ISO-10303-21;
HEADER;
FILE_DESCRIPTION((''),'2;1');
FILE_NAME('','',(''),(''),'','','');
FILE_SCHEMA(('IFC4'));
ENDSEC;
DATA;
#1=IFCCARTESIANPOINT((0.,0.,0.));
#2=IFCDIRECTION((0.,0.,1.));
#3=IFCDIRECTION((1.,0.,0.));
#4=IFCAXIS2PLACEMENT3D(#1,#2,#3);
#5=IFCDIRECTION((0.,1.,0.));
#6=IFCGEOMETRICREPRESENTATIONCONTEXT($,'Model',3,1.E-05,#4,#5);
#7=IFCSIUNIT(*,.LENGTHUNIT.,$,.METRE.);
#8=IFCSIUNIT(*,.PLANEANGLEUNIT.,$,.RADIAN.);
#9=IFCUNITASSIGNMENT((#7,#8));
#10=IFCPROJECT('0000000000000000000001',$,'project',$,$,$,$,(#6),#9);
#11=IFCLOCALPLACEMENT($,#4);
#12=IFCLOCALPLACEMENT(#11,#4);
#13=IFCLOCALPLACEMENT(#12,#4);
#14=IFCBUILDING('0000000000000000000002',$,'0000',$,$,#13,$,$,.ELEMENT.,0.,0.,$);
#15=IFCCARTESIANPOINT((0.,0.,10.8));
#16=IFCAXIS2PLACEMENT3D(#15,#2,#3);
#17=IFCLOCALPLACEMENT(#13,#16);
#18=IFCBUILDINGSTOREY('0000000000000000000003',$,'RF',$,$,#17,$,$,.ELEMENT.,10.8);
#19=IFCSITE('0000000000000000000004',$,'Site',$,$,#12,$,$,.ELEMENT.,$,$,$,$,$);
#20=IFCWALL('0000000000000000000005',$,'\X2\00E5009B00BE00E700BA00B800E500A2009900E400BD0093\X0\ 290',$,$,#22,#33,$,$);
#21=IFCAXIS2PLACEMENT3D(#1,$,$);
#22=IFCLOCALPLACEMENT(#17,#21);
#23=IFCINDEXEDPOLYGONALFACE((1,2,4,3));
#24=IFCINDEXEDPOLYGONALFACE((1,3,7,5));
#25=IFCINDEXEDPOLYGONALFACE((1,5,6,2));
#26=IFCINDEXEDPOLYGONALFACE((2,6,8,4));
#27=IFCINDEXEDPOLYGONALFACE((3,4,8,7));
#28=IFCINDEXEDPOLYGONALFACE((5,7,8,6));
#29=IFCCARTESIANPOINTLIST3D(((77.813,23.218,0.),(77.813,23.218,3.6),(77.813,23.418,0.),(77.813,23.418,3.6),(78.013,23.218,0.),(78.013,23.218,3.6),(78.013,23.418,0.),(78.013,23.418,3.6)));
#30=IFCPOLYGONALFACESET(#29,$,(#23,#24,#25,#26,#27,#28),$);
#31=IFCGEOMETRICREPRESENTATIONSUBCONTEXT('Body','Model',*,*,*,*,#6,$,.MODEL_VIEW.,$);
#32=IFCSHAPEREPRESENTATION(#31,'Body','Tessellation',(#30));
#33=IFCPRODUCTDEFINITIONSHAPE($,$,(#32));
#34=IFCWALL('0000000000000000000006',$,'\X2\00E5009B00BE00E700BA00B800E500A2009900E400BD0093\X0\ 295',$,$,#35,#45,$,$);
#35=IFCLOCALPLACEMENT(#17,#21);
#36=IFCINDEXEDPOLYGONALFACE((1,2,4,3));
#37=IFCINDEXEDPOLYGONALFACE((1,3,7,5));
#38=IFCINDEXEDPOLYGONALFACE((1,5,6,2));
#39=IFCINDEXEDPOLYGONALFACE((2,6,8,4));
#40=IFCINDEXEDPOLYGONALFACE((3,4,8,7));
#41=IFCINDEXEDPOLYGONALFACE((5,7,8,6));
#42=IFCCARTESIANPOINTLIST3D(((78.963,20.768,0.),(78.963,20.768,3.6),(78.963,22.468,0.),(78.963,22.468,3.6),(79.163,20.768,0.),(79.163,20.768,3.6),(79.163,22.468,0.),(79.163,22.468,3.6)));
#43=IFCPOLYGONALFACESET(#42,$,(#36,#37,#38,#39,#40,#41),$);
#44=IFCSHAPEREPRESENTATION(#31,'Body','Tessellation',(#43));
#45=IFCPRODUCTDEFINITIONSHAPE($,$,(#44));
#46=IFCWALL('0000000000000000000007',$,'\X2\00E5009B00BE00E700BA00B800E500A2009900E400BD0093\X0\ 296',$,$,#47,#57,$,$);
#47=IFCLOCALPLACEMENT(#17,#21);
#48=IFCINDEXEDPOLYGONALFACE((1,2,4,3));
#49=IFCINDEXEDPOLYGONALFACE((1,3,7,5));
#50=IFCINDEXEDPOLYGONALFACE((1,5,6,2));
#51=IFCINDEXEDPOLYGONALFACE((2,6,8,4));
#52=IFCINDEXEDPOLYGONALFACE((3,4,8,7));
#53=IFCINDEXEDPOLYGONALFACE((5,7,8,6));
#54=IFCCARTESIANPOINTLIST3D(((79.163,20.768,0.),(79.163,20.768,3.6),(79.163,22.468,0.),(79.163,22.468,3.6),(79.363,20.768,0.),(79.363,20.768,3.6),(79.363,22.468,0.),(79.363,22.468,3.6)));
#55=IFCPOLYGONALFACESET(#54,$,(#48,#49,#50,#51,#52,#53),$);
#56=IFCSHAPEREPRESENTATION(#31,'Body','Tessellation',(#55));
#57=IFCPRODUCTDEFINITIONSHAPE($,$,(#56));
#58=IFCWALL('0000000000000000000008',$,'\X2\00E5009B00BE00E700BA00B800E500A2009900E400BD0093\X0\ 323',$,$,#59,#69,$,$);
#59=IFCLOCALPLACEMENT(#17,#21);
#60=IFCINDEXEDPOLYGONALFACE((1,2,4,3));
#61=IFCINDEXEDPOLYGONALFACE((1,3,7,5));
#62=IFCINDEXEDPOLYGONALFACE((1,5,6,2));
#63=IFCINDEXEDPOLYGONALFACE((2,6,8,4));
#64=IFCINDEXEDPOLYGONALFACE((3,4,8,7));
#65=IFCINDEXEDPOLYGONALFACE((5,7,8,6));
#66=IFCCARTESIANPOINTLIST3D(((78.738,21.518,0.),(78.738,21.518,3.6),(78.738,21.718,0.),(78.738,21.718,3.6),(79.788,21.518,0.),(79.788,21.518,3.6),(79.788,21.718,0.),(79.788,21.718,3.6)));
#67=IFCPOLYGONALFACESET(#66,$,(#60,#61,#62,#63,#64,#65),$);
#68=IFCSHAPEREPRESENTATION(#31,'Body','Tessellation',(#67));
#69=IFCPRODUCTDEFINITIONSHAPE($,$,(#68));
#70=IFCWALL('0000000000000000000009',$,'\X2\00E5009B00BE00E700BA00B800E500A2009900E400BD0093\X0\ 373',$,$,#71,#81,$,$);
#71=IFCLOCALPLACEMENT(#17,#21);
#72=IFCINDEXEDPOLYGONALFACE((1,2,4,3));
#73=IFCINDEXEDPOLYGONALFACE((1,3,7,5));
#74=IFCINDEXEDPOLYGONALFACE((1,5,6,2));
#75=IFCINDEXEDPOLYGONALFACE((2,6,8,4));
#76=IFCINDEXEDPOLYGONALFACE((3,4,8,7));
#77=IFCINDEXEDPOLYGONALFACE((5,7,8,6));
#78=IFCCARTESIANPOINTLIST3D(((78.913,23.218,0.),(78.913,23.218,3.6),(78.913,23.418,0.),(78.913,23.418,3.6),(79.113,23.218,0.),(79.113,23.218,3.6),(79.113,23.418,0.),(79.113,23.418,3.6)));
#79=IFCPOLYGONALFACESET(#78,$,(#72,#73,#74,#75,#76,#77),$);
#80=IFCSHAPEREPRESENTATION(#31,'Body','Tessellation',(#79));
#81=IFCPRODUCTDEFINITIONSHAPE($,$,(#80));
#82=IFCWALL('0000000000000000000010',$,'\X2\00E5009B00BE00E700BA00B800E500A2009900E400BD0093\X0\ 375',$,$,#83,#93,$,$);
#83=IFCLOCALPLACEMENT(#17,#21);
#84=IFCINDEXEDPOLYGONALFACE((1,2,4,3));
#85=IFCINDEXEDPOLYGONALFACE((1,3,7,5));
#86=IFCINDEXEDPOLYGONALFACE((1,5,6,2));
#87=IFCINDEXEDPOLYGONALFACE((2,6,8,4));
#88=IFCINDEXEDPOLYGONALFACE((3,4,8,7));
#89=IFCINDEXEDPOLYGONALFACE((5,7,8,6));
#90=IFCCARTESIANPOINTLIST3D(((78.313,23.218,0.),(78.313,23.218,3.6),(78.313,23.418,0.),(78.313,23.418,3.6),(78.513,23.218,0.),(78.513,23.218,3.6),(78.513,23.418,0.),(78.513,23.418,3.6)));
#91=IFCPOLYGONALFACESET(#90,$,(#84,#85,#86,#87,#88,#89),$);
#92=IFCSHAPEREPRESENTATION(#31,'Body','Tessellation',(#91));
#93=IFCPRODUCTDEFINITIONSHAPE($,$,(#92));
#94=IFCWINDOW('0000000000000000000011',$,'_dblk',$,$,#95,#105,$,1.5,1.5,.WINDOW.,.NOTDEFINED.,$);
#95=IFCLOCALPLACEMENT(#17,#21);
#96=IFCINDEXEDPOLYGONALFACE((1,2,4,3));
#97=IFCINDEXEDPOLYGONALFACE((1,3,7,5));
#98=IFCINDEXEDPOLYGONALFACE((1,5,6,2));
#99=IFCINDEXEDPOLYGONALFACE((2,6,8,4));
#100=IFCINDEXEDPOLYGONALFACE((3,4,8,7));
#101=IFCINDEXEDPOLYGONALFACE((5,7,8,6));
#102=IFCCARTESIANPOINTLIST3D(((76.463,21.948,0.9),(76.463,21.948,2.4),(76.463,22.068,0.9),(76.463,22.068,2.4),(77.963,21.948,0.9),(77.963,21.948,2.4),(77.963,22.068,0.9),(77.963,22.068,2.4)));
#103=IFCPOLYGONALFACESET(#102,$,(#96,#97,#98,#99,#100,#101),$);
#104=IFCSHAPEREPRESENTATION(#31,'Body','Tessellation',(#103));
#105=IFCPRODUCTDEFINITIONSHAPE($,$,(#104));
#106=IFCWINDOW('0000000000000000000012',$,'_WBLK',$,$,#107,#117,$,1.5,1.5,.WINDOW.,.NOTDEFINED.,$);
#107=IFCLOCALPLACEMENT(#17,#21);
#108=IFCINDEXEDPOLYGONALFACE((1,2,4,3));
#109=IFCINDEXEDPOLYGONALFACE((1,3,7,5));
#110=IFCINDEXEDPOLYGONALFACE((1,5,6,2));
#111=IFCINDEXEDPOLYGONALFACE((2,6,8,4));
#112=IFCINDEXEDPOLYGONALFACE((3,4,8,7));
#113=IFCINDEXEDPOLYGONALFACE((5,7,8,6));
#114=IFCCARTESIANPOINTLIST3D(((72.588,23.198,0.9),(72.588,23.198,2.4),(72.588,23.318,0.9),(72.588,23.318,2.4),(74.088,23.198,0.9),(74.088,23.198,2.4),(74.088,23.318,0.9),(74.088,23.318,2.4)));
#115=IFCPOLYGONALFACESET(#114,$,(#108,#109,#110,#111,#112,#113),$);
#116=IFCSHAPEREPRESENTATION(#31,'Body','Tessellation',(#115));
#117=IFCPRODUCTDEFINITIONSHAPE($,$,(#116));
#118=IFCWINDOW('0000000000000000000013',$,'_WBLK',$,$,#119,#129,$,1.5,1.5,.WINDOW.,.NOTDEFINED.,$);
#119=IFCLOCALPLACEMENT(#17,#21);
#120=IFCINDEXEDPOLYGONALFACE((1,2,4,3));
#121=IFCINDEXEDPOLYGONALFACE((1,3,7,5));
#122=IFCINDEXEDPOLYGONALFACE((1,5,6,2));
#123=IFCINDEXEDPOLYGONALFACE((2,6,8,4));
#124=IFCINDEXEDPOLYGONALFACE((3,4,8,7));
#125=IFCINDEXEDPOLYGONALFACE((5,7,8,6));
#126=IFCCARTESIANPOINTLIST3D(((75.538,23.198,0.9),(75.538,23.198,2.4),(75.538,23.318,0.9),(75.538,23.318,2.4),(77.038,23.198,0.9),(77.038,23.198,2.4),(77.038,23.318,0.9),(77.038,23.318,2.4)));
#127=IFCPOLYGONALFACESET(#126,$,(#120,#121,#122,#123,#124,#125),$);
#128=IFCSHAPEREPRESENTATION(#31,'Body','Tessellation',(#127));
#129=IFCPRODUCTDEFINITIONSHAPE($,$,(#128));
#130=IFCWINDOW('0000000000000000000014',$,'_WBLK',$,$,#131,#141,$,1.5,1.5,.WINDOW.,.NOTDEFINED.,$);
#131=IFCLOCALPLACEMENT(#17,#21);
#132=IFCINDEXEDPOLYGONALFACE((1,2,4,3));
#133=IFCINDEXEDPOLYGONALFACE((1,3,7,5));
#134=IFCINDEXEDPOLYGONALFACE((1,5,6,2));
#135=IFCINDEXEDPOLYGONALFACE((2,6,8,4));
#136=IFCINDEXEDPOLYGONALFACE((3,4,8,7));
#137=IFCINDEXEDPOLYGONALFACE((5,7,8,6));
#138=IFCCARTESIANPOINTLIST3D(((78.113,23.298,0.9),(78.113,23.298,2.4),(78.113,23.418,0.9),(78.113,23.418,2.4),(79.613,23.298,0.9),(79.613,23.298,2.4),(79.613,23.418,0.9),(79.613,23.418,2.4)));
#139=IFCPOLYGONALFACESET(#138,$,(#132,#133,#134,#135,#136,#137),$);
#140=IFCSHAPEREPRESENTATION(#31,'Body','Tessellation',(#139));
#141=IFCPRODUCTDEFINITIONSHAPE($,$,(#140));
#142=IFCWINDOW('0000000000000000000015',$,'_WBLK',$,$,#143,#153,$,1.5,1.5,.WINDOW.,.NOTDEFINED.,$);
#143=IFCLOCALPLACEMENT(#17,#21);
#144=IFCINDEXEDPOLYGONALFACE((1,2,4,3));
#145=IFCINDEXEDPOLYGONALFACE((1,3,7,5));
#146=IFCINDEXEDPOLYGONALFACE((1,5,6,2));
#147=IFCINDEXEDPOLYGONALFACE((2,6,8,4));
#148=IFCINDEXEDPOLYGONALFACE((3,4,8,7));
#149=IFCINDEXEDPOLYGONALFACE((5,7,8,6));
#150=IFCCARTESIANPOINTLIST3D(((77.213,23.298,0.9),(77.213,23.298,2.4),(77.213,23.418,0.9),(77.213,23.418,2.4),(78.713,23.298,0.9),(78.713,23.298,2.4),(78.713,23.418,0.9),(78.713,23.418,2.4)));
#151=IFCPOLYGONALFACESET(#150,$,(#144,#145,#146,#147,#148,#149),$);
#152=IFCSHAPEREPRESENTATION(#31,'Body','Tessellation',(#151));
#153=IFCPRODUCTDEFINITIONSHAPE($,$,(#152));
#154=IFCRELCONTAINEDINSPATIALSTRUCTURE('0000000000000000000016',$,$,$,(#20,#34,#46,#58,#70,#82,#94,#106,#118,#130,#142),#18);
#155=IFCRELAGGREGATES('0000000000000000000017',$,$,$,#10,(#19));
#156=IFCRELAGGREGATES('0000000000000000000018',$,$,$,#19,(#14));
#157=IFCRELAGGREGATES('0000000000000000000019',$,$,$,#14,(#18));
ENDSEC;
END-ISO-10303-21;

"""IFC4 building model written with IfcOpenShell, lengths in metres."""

from ifc_helpers import new_model, si_unit, direction, frame, frame_2d, origin_with_axes, place, context, subcontext, project, spatial, rectangle, extrude, element, save


model = new_model("IFC4")

# Units and contexts
model_context = context("Model", 3, precision=1e-05, world=origin_with_axes(), true_north=direction((0.0, 1.0, 0.0)))
body_context = subcontext(model_context, "Body", "Model", "MODEL_VIEW")
ifc_project = project(units=[si_unit("LENGTHUNIT", "METRE"), si_unit("PLANEANGLEUNIT", "RADIAN")], contexts=[model_context])

# Site, building, storey
placement = place(None, origin_with_axes())
site_placement = place(placement, origin_with_axes())
site = spatial("IfcSite", under=ifc_project, at=site_placement, Name="Site", CompositionType="ELEMENT")
building_placement = place(site_placement, origin_with_axes())
building = spatial("IfcBuilding", under=site, at=building_placement, Name="0000", CompositionType="ELEMENT", ElevationOfRefHeight=0.0, ElevationOfTerrain=0.0)
storey_placement = place(building_placement, frame((0.0, 0.0, 10.8), z_axis=(0.0, 0.0, 1.0), x_axis=(1.0, 0.0, 0.0)))
storey = spatial("IfcBuildingStorey", under=building, at=storey_placement, Name="RF", CompositionType="ELEMENT", Elevation=10.8)

# Walls
wall_1_placement = place(storey_placement, frame((77.913, 23.318, 0.0), z_axis=(0.0, 0.0, 1.0), x_axis=(0.0, 1.0, 0.0)))
element("IfcWall", 1, at=wall_1_placement, inside=storey, Name="å\u009b¾çº¸å¢\u0099ä½\u0093 290", context=body_context, shape_type="SweptSolid", body=[
    extrude(rectangle(XDim=0.2, YDim=0.2, at=frame_2d((0.0, 0.0), x_axis=(1.0, 0.0, 0.0))), frame((0.0, 0.0, 0.0), z_axis=(0.0, 0.0, 1.0)), (0.0, 0.0, 1.0), 3.6),
])
for number, where, z_axis, x_axis, name in (
    (2, (79.063, 21.618, 0.0), (0.0, 0.0, 1.0), (0.0, 1.0, 0.0), "å\u009b¾çº¸å¢\u0099ä½\u0093 295"),
    (3, (79.263, 21.618, 0.0), (0.0, 0.0, 1.0), (0.0, 1.0, 0.0), "å\u009b¾çº¸å¢\u0099ä½\u0093 296"),
):
    element("IfcWall", number, at=place(storey_placement, frame(where, z_axis=z_axis, x_axis=x_axis)), inside=storey, Name=name, context=body_context, shape_type="SweptSolid", body=[
        extrude(rectangle(XDim=1.7, YDim=0.2, at=frame_2d((0.0, 0.0), x_axis=(1.0, 0.0, 0.0))), frame((0.0, 0.0, 0.0), z_axis=(0.0, 0.0, 1.0)), (0.0, 0.0, 1.0), 3.6),
    ])
wall_2_placement = place(storey_placement, frame((79.263, 21.618, 0.0), z_axis=(0.0, 0.0, 1.0), x_axis=(1.0, 0.0, 0.0)))
element("IfcWall", 4, at=wall_2_placement, inside=storey, Name="å\u009b¾çº¸å¢\u0099ä½\u0093 323", context=body_context, shape_type="SweptSolid", body=[
    extrude(rectangle(XDim=1.05, YDim=0.2, at=frame_2d((0.0, 0.0), x_axis=(1.0, 0.0, 0.0))), frame((0.0, 0.0, 0.0), z_axis=(0.0, 0.0, 1.0)), (0.0, 0.0, 1.0), 3.6),
])
for number, where, z_axis, x_axis, name in (
    (5, (79.013, 23.318, 0.0), (0.0, 0.0, 1.0), (1.0, 0.0, 0.0), "å\u009b¾çº¸å¢\u0099ä½\u0093 373"),
    (6, (78.413, 23.318, 0.0), (0.0, 0.0, 1.0), (0.0, 1.0, 0.0), "å\u009b¾çº¸å¢\u0099ä½\u0093 375"),
):
    element("IfcWall", number, at=place(storey_placement, frame(where, z_axis=z_axis, x_axis=x_axis)), inside=storey, Name=name, context=body_context, shape_type="SweptSolid", body=[
        extrude(rectangle(XDim=0.2, YDim=0.2, at=frame_2d((0.0, 0.0), x_axis=(1.0, 0.0, 0.0))), frame((0.0, 0.0, 0.0), z_axis=(0.0, 0.0, 1.0)), (0.0, 0.0, 1.0), 3.6),
    ])

# Windows
for number, where, z_axis, x_axis, name in (
    (7, (77.213, 22.008, 0.9), (0.0, 0.0, 1.0), (1.0, 0.0, 0.0), "_dblk"),
    (8, (73.338, 23.258, 0.9), (0.0, 0.0, 1.0), (1.0, 0.0, 0.0), "_WBLK"),
    (9, (76.288, 23.258, 0.9), (0.0, 0.0, 1.0), (1.0, 0.0, 0.0), "_WBLK"),
    (10, (78.863, 23.358, 0.9), (0.0, 0.0, 1.0), (1.0, 0.0, 0.0), "_WBLK"),
    (11, (77.963, 23.358, 0.9), (0.0, 0.0, 1.0), (1.0, 0.0, 0.0), "_WBLK"),
):
    element("IfcWindow", number, at=place(storey_placement, frame(where, z_axis=z_axis, x_axis=x_axis)), inside=storey, Name=name, OverallHeight=1.5, OverallWidth=1.5, PartitioningType="NOTDEFINED", PredefinedType="WINDOW", context=body_context, shape_type="SweptSolid", body=[
        extrude(rectangle(XDim=1.5, YDim=0.12, at=frame_2d((0.0, 0.0), x_axis=(1.0, 0.0, 0.0))), frame((0.0, 0.0, 0.0), z_axis=(0.0, 0.0, 1.0)), (0.0, 0.0, 1.0), 1.5),
    ])

save(model, "model.ifc")
